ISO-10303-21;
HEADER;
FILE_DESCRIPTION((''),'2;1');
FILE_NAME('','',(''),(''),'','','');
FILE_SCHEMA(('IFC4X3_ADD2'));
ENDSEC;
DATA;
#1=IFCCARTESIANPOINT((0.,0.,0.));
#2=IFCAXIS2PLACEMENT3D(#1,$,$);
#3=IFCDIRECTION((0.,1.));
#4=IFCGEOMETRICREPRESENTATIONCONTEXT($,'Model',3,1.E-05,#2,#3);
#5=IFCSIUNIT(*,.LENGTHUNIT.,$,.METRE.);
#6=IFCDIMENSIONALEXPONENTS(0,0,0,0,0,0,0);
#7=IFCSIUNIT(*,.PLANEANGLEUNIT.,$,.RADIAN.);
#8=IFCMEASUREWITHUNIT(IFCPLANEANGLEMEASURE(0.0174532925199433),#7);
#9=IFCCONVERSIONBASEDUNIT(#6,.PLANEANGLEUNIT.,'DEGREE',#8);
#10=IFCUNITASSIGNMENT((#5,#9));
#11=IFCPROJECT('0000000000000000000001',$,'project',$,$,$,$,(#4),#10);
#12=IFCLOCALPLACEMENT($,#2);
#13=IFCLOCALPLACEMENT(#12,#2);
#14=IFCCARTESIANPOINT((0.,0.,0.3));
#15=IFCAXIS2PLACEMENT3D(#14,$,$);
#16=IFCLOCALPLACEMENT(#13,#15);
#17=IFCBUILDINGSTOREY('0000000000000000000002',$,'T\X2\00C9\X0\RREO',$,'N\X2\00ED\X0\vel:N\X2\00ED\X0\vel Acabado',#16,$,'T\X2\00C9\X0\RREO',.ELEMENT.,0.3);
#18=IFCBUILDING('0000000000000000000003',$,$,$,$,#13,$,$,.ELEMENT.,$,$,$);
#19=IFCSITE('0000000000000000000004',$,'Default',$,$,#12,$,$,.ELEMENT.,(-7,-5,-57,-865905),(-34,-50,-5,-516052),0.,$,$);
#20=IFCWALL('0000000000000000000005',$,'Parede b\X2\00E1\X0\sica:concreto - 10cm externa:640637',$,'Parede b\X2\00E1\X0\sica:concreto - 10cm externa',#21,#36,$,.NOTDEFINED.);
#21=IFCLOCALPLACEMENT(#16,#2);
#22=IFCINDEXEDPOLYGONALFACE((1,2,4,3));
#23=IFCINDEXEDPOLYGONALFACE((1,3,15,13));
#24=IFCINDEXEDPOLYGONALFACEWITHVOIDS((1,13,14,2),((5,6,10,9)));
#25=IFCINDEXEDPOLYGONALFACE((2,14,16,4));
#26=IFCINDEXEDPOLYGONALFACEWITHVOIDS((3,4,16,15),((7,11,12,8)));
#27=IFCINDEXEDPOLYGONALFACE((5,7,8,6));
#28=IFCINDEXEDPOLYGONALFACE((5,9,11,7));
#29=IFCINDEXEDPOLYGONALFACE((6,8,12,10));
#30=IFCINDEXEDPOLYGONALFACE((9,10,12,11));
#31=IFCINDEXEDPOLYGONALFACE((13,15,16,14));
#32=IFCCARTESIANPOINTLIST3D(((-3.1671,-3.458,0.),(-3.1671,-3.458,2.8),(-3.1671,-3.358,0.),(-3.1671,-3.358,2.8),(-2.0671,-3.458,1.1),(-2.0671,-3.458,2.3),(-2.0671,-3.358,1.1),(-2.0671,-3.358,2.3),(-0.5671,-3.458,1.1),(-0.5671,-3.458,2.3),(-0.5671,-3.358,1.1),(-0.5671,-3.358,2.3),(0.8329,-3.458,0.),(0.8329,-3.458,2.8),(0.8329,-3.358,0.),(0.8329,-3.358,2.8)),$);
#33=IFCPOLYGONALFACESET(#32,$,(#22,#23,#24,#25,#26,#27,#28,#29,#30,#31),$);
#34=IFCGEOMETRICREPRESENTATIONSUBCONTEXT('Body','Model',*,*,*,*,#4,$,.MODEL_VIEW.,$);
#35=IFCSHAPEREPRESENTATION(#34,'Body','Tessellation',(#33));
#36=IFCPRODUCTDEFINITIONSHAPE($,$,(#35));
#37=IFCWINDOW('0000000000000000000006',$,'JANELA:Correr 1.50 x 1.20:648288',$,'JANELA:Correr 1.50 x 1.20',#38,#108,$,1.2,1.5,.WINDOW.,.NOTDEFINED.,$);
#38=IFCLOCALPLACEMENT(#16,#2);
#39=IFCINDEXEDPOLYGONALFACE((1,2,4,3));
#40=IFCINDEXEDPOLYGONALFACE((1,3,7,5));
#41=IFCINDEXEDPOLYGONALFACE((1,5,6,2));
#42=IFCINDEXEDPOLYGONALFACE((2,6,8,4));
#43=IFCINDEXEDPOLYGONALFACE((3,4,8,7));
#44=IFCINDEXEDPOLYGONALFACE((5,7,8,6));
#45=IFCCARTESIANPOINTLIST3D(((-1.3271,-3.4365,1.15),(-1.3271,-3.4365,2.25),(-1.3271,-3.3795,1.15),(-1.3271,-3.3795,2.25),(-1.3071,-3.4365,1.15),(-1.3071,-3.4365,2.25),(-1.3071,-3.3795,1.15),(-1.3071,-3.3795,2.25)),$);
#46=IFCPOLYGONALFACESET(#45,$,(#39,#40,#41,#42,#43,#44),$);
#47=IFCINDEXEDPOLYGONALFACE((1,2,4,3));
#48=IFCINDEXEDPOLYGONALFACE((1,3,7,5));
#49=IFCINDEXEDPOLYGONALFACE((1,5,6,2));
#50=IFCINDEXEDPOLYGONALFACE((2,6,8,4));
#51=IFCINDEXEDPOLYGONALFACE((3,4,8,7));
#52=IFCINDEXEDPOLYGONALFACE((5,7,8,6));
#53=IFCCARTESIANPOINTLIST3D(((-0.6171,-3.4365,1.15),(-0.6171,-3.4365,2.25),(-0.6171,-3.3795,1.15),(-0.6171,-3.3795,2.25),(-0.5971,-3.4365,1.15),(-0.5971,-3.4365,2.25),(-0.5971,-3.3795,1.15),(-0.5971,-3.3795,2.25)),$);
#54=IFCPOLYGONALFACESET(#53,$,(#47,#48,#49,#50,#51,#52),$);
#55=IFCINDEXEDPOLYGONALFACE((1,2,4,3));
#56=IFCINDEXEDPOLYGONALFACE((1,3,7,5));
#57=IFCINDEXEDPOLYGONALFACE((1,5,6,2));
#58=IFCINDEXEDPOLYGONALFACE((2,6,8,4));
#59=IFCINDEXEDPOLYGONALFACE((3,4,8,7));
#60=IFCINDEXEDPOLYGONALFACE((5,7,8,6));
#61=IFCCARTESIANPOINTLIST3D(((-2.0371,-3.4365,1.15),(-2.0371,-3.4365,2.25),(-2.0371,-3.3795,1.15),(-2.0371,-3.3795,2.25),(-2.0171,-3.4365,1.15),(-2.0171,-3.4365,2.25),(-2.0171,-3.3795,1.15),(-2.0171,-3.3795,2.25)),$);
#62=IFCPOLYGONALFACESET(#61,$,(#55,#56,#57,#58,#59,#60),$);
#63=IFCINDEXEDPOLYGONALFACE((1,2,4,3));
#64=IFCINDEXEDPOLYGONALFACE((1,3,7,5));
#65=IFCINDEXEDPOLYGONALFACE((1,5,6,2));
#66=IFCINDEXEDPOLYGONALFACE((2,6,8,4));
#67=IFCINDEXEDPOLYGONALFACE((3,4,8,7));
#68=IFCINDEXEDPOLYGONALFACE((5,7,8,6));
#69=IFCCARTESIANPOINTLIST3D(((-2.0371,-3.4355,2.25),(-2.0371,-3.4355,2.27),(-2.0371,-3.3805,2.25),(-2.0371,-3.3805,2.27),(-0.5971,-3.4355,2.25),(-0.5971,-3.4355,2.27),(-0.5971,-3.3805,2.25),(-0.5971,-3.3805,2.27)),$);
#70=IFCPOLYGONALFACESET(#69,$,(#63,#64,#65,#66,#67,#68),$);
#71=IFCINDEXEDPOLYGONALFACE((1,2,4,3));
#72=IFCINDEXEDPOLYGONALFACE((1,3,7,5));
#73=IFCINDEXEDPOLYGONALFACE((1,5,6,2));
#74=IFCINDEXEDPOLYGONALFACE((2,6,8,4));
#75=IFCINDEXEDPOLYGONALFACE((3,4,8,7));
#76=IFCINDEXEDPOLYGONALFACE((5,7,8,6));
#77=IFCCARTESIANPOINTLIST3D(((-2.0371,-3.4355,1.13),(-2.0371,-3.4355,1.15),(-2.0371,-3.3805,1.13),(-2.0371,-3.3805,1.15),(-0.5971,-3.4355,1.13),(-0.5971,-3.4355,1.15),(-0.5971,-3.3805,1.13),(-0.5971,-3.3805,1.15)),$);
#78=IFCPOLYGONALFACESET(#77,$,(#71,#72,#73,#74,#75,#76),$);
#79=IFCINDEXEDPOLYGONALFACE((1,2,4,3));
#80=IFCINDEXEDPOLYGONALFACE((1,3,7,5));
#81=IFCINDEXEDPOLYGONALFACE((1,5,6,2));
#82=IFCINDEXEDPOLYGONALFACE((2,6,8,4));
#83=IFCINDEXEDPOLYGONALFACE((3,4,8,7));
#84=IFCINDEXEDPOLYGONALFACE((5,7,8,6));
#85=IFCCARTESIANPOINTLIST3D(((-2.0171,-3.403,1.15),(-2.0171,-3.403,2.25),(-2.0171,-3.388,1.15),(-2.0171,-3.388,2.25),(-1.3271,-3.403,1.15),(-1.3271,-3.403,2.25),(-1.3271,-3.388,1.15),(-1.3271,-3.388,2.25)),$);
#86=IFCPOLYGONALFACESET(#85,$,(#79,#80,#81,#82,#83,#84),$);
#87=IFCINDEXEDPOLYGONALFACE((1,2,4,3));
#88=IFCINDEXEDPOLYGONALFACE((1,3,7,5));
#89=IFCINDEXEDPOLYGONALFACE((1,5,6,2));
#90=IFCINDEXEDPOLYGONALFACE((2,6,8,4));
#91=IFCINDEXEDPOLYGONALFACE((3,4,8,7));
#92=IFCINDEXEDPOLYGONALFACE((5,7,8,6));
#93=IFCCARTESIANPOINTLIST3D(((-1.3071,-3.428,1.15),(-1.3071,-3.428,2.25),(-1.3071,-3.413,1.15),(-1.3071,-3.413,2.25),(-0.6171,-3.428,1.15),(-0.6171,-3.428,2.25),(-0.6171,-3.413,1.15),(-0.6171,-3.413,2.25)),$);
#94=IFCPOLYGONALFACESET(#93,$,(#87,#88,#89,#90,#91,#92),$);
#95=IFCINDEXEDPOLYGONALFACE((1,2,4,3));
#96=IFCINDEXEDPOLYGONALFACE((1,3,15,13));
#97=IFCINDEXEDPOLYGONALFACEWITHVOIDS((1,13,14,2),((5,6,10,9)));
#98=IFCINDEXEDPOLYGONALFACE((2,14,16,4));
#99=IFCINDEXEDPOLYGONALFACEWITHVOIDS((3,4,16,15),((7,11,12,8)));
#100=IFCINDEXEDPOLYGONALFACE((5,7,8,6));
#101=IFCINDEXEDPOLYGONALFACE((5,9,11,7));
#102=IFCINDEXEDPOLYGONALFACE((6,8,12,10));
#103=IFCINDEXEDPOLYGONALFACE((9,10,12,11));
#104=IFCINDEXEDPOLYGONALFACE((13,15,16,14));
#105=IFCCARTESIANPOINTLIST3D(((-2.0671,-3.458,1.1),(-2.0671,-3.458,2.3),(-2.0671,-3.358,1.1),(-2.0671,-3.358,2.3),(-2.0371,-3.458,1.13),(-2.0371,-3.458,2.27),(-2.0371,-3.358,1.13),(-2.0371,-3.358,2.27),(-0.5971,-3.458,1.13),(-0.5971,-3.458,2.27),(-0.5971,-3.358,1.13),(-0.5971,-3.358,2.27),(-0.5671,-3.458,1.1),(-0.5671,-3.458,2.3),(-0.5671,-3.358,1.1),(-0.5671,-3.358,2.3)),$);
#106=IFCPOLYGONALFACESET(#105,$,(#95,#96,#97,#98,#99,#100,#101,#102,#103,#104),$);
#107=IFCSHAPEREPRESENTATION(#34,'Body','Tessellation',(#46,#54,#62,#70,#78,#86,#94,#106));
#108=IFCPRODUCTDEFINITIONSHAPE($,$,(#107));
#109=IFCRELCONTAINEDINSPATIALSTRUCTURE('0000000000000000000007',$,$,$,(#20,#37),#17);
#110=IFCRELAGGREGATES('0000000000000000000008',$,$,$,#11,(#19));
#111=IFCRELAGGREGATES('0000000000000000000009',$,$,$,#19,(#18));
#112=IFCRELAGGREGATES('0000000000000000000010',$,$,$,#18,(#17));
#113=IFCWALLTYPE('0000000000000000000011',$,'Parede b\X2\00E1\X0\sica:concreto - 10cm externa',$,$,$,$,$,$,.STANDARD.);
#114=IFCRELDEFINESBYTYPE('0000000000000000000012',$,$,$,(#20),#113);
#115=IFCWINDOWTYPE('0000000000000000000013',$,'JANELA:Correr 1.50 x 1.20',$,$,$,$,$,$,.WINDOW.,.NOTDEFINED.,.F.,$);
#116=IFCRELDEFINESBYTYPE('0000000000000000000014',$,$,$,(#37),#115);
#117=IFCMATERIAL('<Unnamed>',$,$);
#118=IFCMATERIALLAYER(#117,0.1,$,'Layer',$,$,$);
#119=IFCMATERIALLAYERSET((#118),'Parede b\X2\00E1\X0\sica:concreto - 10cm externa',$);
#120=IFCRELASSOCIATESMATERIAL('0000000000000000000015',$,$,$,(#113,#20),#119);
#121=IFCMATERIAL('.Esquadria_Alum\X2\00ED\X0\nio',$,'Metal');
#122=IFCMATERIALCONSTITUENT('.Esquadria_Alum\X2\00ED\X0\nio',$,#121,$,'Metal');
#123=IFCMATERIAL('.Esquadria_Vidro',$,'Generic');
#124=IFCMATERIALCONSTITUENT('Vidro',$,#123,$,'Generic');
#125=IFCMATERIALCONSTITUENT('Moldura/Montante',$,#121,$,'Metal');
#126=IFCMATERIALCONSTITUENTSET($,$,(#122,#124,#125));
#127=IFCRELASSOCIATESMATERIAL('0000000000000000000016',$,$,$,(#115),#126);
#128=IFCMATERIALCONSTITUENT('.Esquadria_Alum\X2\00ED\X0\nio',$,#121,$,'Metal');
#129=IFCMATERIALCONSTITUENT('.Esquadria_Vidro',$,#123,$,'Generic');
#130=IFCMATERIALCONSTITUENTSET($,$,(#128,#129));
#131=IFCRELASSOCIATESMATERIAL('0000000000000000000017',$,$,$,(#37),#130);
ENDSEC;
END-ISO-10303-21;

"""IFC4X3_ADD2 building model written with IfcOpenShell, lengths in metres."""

from ifc_helpers import new_model, entity, si_unit, converted_unit, direction, frame, frame_2d, origin, origin_2d_with_axis, place, context, subcontext, project, spatial, polyline, rectangle, outline, extrude, source, transform, mapped, material, layer, layer_set, constituent, constituent_set, type_object, type_shapes, element, fill, save


model = new_model("IFC4X3_ADD2")

# Units and contexts
model_context = context("Model", 3, precision=1e-05, world=origin(), true_north=direction((0.0, 1.0)))
body_context = subcontext(model_context, "Body", "Model", "MODEL_VIEW")
ifc_project = project(units=[si_unit("LENGTHUNIT", "METRE"), converted_unit("PLANEANGLEUNIT", "DEGREE", entity("IfcPlaneAngleMeasure", 0.0174532925199433), si_unit("PLANEANGLEUNIT", "RADIAN"), dimensions=[0, 0, 0, 0, 0, 0, 0])], contexts=[model_context])

# Site, building, storey
site_placement = place(None, origin())
site = spatial("IfcSite", under=ifc_project, at=site_placement, Name="Default", CompositionType="ELEMENT", RefLatitude=(-7, -5, -57, -865905), RefLongitude=(-34, -50, -5, -516052), RefElevation=0.0)
building_placement = place(site_placement, origin())
building = spatial("IfcBuilding", under=site, at=building_placement, CompositionType="ELEMENT")
storey_placement = place(building_placement, frame((0.0, 0.0, 0.3)))
storey = spatial("IfcBuildingStorey", under=building, at=storey_placement, Name="TÉRREO", ObjectType="Nível:Nível Acabado", LongName="TÉRREO", CompositionType="ELEMENT", Elevation=0.3)

# Wall, opening, window
ifc_material_1 = material(Name="<Unnamed>")
ifc_layer_1 = layer(ifc_material_1, 0.1, Name="Layer")
ifc_layer_set_1 = layer_set([ifc_layer_1], Name="Parede básica:concreto - 10cm externa")
wall_type_1 = type_object("IfcWallType", Name="Parede básica:concreto - 10cm externa", PredefinedType="STANDARD", material=ifc_layer_set_1)
wall_1_placement = place(storey_placement, frame((0.8329, -3.408, 0.0), z_axis=(0.0, 0.0, 1.0), x_axis=(-1.0, 0.0, 0.0)))
wall_1 = element("IfcWall", 1, at=wall_1_placement, inside=storey, type_object=wall_type_1, material=ifc_layer_set_1, Name="Parede básica:concreto - 10cm externa:640637", ObjectType="Parede básica:concreto - 10cm externa", PredefinedType="NOTDEFINED", context=body_context, shape_type="SweptSolid", body=[
    extrude(rectangle(XDim=4.0, YDim=0.1, at=frame_2d((2.0, 0.0), x_axis=(-1.0, 0.0))), origin(), (0.0, 0.0, 1.0), 2.8),
])
opening_1_placement = place(wall_1_placement, frame((1.4, -0.05, 1.1)))
opening_1 = element("IfcOpeningElement", 2, at=opening_1_placement, cuts=wall_1, PredefinedType="OPENING", context=body_context, shape_type="SweptSolid", body=[
    extrude(rectangle(XDim=1.2, YDim=1.5, at=frame_2d((0.6, 0.75), x_axis=(1.0, 0.0))), frame((0.0, 0.0, 0.0), z_axis=(0.0, 1.0, 0.0), x_axis=(0.0, 0.0, 1.0)), (0.0, 0.0, 1.0), 0.1),
])
ifc_material_2 = material(Name=".Esquadria_Alumínio", Category="Metal")
ifc_constituent_1 = constituent(ifc_material_2, Name=".Esquadria_Alumínio", Category="Metal")
ifc_material_3 = material(Name=".Esquadria_Vidro", Category="Generic")
ifc_constituent_2 = constituent(ifc_material_3, Name=".Esquadria_Vidro", Category="Generic")
ifc_constituent_set_1 = constituent_set(constituents=[ifc_constituent_1, ifc_constituent_2])
ifc_constituent_3 = constituent(ifc_material_2, Name=".Esquadria_Alumínio", Category="Metal")
ifc_constituent_4 = constituent(ifc_material_3, Name="Vidro", Category="Generic")
ifc_constituent_5 = constituent(ifc_material_2, Name="Moldura/Montante", Category="Metal")
ifc_constituent_set_2 = constituent_set(constituents=[ifc_constituent_3, ifc_constituent_4, ifc_constituent_5])
window_type_1 = type_object("IfcWindowType", Name="JANELA:Correr 1.50 x 1.20", ParameterTakesPrecedence=False, PartitioningType="NOTDEFINED", PredefinedType="WINDOW", material=ifc_constituent_set_2)
shared_shape_1 = source(origin(), body_context, "Body", "SweptSolid", [
    extrude(rectangle(XDim=0.02, YDim=0.057, at=origin_2d_with_axis()), frame((0.75, 0.05, 0.05), z_axis=(0.0, 0.0, 1.0), x_axis=(-1.0, 0.0, 0.0)), (0.0, 0.0, 1.0), 1.1),
    extrude(rectangle(XDim=0.02, YDim=0.057, at=origin_2d_with_axis()), frame((0.04, 0.05, 0.05), z_axis=(0.0, 0.0, 1.0), x_axis=(-1.0, 0.0, 0.0)), (0.0, 0.0, 1.0), 1.1),
    extrude(rectangle(XDim=0.02, YDim=0.057, at=origin_2d_with_axis()), frame((1.46, 0.05, 0.05), z_axis=(0.0, 0.0, 1.0), x_axis=(-1.0, 0.0, 0.0)), (0.0, 0.0, 1.0), 1.1),
    extrude(rectangle(XDim=1.44, YDim=0.055, at=origin_2d_with_axis()), frame((0.75, 0.05, 1.15), z_axis=(0.0, 0.0, 1.0), x_axis=(-1.0, 0.0, 0.0)), (0.0, 0.0, 1.0), 0.02),
    extrude(rectangle(XDim=1.44, YDim=0.055, at=origin_2d_with_axis()), frame((0.75, 0.05, 0.03), z_axis=(0.0, 0.0, 1.0), x_axis=(-1.0, 0.0, 0.0)), (0.0, 0.0, 1.0), 0.02),
    extrude(rectangle(XDim=0.015, YDim=0.69, at=frame_2d((0.0, 0.0), x_axis=(1.0, 0.0))), frame((1.105, 0.0375, 0.05), z_axis=(0.0, 0.0, 1.0), x_axis=(0.0, 1.0, 0.0)), (0.0, 0.0, 1.0), 1.1),
    extrude(rectangle(XDim=0.015, YDim=0.69, at=origin_2d_with_axis()), frame((0.395, 0.0625, 0.05), z_axis=(0.0, 0.0, 1.0), x_axis=(0.0, 1.0, 0.0)), (0.0, 0.0, 1.0), 1.1),
    extrude(outline(polyline([(-0.75, -0.6), (0.75, -0.6), (0.75, 0.6), (-0.75, 0.6), (-0.75, -0.6)]), holes=[polyline([(0.72, -0.57), (-0.72, -0.57), (-0.72, 0.57), (0.72, 0.57), (0.72, -0.57)])]), frame((0.75, 0.0, 0.6), z_axis=(0.0, 1.0, 0.0), x_axis=(1.0, 0.0, 0.0)), (0.0, 0.0, 1.0), 0.1),
])
type_shapes(window_type_1, [shared_shape_1])
window_1_placement = place(opening_1_placement, origin())
window_1 = element("IfcWindow", 3, at=window_1_placement, inside=storey, type_object=window_type_1, material=ifc_constituent_set_1, Name="JANELA:Correr 1.50 x 1.20:648288", ObjectType="JANELA:Correr 1.50 x 1.20", OverallHeight=1.2, OverallWidth=1.5, PartitioningType="NOTDEFINED", PredefinedType="WINDOW", context=body_context, shape_type="MappedRepresentation", body=[
    mapped(shared_shape_1, transform((0.0, 0.0, 0.0), scale=1.0)),
])
fill(opening_1, window_1)

save(model, "model.ifc")
